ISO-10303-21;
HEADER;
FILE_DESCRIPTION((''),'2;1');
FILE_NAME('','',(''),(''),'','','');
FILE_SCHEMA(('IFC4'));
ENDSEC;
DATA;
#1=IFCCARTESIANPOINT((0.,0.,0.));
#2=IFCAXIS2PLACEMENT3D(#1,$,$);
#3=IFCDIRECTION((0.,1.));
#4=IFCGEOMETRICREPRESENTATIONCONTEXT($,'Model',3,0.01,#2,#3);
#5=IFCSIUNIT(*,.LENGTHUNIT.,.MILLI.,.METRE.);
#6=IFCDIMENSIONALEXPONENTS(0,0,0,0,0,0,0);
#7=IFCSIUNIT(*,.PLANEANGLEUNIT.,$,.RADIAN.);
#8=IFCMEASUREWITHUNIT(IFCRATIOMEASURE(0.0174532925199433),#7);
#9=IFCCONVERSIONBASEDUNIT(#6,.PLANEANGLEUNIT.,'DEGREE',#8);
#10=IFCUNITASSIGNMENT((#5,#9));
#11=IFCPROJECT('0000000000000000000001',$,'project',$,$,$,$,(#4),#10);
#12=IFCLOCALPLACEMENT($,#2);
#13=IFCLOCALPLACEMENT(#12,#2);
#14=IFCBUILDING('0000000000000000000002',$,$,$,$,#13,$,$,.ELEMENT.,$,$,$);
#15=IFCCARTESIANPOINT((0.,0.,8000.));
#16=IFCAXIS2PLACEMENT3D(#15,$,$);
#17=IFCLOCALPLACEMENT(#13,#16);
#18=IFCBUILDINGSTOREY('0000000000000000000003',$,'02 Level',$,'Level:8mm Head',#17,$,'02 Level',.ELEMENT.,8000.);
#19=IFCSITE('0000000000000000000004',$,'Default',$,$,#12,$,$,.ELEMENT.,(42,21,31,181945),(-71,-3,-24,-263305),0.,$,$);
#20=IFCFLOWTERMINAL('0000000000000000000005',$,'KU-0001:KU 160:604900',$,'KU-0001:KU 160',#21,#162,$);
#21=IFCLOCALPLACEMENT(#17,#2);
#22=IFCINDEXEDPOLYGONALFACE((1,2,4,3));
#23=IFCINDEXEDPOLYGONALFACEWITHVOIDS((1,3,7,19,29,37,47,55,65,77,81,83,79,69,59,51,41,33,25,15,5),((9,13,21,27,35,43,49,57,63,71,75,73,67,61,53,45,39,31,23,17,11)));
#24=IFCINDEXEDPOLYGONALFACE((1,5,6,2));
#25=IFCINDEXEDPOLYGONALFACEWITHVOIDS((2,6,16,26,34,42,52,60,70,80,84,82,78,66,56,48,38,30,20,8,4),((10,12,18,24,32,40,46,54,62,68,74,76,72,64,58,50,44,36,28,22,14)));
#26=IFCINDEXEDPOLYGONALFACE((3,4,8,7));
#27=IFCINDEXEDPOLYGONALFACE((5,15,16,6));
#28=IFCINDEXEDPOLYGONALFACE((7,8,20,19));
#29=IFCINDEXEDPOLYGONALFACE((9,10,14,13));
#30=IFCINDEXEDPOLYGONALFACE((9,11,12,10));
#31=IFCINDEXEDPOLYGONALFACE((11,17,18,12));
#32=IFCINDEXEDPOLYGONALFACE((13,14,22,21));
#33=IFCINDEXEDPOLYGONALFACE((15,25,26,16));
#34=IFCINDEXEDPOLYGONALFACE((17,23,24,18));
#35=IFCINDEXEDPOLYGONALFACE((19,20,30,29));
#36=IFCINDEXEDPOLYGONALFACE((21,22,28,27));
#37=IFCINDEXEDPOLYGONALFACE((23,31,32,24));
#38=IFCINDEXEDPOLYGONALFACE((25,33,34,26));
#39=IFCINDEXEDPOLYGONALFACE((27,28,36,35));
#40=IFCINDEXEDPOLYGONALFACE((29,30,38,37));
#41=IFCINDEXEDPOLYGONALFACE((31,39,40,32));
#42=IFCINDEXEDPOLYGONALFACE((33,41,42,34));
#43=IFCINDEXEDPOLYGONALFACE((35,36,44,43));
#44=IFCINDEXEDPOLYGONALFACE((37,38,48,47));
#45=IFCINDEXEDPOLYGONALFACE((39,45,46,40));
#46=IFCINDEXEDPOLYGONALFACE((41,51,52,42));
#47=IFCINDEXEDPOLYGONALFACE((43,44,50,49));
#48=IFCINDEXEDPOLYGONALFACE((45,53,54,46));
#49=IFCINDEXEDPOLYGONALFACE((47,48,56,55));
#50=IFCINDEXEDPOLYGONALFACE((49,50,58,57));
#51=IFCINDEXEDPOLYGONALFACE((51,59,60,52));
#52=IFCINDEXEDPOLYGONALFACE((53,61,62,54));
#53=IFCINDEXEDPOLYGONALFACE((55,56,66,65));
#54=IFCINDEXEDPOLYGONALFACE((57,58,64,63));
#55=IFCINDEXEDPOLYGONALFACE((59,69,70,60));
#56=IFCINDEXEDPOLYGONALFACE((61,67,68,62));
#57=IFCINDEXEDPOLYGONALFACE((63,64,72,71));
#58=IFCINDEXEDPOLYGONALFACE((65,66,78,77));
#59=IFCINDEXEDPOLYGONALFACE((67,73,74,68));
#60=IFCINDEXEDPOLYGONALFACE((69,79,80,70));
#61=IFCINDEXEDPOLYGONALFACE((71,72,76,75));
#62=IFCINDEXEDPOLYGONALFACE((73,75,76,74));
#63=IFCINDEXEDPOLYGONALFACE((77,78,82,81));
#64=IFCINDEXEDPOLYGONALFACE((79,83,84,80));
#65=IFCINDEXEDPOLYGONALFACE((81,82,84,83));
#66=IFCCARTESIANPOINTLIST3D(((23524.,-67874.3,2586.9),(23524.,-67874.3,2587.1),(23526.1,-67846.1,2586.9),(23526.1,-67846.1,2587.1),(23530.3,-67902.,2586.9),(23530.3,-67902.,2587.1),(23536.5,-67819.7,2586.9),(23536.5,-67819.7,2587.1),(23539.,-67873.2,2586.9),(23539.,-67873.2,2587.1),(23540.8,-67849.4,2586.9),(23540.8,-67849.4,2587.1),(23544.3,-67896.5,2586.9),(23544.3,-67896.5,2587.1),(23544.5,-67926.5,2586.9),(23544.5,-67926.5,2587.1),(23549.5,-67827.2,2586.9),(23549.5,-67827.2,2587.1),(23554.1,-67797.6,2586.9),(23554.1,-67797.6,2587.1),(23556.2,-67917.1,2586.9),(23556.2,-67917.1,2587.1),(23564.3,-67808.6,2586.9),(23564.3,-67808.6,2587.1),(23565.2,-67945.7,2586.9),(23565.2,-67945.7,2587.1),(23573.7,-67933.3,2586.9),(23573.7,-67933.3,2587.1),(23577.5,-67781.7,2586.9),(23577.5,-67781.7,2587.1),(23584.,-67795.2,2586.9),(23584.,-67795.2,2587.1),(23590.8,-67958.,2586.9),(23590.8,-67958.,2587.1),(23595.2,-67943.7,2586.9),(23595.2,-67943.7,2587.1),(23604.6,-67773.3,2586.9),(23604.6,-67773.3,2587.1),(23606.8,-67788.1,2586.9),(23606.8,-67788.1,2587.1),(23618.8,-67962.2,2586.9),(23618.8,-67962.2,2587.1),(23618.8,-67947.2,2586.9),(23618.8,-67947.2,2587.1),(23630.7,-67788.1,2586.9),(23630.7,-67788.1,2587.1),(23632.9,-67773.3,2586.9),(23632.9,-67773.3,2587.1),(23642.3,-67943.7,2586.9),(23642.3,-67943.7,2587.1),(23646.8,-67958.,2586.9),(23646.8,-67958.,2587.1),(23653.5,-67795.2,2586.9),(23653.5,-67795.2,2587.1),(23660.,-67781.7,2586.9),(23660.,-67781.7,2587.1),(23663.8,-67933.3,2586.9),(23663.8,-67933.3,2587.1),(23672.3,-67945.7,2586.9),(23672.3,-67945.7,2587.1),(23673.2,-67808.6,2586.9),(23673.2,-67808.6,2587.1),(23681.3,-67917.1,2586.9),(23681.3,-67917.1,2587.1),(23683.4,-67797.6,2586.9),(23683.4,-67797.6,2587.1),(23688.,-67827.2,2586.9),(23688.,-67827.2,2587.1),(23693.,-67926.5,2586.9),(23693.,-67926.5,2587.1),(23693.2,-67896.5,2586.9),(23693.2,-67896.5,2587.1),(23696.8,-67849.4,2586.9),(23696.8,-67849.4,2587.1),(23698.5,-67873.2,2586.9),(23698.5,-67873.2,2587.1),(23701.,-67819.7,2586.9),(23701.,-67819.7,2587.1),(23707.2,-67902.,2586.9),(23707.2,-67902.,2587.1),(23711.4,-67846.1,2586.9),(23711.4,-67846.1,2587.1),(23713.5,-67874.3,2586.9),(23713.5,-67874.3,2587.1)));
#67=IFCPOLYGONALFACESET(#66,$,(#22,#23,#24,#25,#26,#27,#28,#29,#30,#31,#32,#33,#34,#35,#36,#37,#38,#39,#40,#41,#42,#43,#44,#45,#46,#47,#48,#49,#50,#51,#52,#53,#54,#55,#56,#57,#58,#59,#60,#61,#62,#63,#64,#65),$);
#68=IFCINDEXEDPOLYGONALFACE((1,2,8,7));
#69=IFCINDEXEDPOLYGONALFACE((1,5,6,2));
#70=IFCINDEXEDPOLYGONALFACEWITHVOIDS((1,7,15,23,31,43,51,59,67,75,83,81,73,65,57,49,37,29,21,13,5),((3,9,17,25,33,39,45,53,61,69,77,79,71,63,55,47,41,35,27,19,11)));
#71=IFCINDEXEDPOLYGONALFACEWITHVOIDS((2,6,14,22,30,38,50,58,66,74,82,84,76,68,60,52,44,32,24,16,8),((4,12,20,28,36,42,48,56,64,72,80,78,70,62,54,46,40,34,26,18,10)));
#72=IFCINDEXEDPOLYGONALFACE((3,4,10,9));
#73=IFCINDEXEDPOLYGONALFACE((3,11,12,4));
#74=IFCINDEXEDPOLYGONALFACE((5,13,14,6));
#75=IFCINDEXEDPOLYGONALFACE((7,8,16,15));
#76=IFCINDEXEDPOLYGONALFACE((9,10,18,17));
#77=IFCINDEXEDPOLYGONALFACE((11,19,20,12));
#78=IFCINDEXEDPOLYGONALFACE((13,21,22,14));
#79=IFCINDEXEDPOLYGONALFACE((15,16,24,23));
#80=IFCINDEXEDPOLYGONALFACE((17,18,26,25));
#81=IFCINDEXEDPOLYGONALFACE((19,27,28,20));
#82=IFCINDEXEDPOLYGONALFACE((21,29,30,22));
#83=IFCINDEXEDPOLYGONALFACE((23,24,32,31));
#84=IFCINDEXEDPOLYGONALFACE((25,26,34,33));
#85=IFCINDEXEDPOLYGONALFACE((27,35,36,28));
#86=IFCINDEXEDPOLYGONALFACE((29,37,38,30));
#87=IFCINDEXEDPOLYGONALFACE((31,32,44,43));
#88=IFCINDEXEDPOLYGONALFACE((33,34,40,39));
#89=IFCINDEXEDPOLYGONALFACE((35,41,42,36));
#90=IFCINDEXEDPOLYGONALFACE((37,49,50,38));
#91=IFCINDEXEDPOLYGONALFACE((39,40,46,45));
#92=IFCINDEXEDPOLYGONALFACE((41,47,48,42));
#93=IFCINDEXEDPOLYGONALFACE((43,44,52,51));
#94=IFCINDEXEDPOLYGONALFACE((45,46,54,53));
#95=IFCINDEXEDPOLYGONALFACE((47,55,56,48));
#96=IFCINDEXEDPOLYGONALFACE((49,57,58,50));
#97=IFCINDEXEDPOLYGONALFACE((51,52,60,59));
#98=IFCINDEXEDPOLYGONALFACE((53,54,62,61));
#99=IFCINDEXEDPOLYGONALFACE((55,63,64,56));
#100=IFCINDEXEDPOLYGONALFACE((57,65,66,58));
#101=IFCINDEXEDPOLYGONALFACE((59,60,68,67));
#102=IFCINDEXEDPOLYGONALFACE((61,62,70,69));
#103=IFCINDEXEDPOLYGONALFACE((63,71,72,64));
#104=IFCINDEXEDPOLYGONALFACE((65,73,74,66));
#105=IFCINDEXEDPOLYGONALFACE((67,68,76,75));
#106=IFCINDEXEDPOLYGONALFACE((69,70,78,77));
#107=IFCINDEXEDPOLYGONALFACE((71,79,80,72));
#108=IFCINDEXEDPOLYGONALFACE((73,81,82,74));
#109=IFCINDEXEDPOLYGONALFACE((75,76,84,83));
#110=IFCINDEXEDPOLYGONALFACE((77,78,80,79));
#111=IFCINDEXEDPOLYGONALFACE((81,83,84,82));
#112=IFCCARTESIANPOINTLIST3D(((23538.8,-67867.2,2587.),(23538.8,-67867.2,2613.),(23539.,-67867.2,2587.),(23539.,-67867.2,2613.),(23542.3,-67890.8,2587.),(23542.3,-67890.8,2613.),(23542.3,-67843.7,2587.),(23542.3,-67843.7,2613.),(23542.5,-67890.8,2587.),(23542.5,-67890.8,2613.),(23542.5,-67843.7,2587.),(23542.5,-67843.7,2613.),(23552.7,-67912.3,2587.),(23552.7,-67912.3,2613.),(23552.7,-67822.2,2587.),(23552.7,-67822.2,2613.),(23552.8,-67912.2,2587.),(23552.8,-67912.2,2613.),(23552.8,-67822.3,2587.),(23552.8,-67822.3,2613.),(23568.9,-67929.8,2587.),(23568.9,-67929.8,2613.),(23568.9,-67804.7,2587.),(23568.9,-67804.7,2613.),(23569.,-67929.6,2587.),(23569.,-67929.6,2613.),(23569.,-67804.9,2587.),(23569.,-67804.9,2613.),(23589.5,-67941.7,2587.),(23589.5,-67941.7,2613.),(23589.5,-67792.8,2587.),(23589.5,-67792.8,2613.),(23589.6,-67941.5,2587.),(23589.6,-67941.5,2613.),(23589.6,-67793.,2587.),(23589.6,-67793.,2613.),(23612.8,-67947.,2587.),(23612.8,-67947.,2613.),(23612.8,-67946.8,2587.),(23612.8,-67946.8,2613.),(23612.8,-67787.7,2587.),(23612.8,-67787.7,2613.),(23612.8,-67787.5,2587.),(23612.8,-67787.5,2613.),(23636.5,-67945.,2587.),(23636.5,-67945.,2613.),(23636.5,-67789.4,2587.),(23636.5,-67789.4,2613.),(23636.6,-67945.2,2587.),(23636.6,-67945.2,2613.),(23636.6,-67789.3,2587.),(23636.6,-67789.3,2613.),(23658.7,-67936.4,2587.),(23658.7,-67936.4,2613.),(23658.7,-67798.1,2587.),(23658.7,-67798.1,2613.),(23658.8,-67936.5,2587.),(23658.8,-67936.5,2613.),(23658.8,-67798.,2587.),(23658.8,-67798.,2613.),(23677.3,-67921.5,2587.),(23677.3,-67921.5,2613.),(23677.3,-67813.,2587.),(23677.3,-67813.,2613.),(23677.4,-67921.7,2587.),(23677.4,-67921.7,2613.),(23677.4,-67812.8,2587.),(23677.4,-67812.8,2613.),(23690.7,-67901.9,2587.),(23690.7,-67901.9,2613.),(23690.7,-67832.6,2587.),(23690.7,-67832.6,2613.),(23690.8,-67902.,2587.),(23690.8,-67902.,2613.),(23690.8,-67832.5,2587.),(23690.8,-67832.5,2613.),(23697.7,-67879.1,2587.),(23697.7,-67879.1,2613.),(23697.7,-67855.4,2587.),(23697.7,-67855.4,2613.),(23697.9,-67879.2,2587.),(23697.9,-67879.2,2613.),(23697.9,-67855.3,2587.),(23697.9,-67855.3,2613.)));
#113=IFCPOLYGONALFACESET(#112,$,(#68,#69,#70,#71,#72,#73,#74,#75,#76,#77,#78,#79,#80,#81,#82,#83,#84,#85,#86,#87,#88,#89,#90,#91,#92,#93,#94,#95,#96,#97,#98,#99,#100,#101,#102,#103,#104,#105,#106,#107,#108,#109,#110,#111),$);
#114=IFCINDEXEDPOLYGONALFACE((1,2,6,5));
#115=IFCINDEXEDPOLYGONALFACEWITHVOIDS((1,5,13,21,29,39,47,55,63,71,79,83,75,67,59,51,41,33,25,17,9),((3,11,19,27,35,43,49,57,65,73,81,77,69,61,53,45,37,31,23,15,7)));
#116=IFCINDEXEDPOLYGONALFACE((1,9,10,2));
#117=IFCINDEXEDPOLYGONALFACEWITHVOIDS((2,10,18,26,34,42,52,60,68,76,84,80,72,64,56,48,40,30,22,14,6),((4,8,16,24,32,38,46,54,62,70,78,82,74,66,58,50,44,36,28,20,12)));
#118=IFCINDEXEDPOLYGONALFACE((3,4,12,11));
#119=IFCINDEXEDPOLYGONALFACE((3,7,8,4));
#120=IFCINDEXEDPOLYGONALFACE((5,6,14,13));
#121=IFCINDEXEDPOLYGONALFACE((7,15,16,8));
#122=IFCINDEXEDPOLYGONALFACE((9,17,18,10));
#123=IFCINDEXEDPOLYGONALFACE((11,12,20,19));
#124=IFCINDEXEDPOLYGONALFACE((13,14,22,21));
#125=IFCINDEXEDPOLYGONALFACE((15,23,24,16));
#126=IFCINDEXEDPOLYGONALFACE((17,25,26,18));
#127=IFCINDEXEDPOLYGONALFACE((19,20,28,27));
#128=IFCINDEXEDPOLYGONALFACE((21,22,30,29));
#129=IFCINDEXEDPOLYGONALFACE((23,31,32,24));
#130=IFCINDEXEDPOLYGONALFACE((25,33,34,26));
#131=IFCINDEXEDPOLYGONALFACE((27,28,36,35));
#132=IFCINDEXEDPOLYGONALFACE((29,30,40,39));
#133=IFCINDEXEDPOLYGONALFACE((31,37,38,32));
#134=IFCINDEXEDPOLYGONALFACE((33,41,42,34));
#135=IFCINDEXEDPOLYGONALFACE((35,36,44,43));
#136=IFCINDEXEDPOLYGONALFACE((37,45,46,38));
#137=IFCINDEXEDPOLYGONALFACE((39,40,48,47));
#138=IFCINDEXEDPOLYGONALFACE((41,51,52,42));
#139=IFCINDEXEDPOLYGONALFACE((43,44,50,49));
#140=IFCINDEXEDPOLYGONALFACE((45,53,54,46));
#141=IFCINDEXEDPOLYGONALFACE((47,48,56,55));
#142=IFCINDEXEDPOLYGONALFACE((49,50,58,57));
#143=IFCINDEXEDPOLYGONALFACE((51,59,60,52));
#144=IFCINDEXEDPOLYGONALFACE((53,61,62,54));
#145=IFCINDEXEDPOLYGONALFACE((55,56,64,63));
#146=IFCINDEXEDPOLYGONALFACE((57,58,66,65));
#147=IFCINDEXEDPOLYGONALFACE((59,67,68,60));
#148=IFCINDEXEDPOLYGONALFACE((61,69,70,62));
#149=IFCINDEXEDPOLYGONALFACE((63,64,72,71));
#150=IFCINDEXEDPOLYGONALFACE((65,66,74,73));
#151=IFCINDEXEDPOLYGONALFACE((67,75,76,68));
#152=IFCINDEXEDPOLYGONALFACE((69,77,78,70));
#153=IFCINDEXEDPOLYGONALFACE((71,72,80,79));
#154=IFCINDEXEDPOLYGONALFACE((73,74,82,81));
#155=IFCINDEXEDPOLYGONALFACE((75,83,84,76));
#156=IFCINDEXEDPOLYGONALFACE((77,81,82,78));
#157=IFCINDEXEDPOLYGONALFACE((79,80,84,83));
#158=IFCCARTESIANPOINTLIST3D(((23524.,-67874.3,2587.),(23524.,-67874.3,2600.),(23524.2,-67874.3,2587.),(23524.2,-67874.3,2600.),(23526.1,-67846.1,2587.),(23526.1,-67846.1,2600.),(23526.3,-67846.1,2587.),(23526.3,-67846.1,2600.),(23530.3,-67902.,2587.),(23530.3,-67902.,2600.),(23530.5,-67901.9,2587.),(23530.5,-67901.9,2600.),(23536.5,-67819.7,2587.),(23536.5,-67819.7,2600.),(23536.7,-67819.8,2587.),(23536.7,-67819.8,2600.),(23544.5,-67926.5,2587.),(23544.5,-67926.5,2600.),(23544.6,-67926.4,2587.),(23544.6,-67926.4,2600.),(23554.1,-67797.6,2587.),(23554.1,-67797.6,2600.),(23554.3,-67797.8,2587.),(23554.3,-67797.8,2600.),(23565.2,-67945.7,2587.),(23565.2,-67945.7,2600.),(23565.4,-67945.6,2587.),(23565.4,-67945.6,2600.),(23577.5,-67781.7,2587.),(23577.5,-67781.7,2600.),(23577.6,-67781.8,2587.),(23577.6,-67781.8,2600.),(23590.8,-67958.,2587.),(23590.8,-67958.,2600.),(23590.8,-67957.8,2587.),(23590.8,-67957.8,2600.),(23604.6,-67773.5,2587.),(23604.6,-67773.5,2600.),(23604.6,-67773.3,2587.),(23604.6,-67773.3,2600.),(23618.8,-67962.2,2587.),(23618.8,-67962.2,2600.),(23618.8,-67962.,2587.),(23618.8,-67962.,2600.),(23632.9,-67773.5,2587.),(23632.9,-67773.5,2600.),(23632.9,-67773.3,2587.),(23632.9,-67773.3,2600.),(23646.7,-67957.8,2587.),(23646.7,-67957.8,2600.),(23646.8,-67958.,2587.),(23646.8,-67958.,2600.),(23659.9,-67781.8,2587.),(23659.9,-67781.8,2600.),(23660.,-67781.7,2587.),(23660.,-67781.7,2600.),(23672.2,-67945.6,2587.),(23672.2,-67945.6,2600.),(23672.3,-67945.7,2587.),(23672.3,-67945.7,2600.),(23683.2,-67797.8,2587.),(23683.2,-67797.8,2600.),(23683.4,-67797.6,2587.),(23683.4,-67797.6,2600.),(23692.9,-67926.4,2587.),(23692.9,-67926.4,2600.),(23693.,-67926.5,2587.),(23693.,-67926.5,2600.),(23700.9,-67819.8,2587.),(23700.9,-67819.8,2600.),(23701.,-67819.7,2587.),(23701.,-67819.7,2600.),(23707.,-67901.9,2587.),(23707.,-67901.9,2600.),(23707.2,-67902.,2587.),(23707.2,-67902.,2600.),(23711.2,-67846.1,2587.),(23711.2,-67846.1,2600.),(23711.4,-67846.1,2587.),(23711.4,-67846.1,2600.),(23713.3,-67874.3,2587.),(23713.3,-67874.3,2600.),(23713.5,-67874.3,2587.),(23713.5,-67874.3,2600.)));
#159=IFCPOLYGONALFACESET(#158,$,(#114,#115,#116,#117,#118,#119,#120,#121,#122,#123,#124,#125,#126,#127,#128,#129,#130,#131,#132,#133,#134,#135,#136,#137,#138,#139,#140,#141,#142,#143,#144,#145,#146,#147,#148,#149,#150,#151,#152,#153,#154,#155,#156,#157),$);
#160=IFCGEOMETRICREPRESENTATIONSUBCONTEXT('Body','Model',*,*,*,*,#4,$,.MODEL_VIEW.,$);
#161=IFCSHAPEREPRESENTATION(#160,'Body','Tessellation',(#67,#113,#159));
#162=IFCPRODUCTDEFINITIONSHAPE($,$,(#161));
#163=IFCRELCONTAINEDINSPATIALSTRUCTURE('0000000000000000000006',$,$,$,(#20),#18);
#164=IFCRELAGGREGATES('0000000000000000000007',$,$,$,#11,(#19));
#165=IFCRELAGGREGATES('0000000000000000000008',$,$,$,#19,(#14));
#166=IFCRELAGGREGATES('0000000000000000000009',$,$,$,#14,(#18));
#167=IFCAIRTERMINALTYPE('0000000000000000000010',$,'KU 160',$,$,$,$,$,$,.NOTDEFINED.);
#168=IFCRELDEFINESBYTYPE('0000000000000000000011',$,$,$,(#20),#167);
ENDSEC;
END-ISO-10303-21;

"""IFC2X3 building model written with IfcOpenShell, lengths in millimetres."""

from ifc_helpers import new_model, entity, si_unit, converted_unit, direction, frame, frame_2d, origin, place, context, subcontext, project, spatial, hollow_circle, extrude, source, transform, mapped, type_object, type_shapes, element, save


model = new_model("IFC2X3")

# Units and contexts
model_context = context("Model", 3, precision=0.01, world=origin(), true_north=direction((0.0, 1.0)))
body_context = subcontext(model_context, "Body", "Model", "MODEL_VIEW")
ifc_project = project(units=[si_unit("LENGTHUNIT", "METRE", prefix="MILLI"), converted_unit("PLANEANGLEUNIT", "DEGREE", entity("IfcRatioMeasure", 0.0174532925199433), si_unit("PLANEANGLEUNIT", "RADIAN"), dimensions=[0, 0, 0, 0, 0, 0, 0])], contexts=[model_context])

# Site, building, storey
site_placement = place(None, origin())
site = spatial("IfcSite", under=ifc_project, at=site_placement, Name="Default", CompositionType="ELEMENT", RefLatitude=(42, 21, 31, 181945), RefLongitude=(-71, -3, -24, -263305), RefElevation=0.0)
building_placement = place(site_placement, origin())
building = spatial("IfcBuilding", under=site, at=building_placement, CompositionType="ELEMENT")
storey_placement = place(building_placement, frame((0.0, 0.0, 8000.0)))
storey = spatial("IfcBuildingStorey", under=building, at=storey_placement, Name="02 Level", ObjectType="Level:8mm Head", LongName="02 Level", CompositionType="ELEMENT", Elevation=8000.0)

# Flow terminal
air_terminal_type_1 = type_object("IfcAirTerminalType", Name="KU 160", PredefinedType="NOTDEFINED")
shared_shape_1 = source(origin(), body_context, "Body", "SweptSolid", [
    extrude(hollow_circle(Radius=95.0, WallThickness=15.0, at=frame_2d((0.0, 0.0), x_axis=(1.0, 0.0))), frame((12.9, 0.0, 0.0), z_axis=(1.0, 0.0, 0.0), x_axis=(0.0, -1.0, 0.0)), (0.0, 0.0, 1.0), 0.2),
    extrude(hollow_circle(Radius=80.0, WallThickness=0.2, at=frame_2d((0.0, 0.0), x_axis=(1.0, 0.0))), frame((-13.0, 0.0, 0.0), z_axis=(1.0, 0.0, 0.0), x_axis=(0.0, 0.0, -1.0)), (0.0, 0.0, 1.0), 26.0),
    extrude(hollow_circle(Radius=95.0, WallThickness=0.2, at=frame_2d((0.0, 0.0), x_axis=(1.0, 0.0))), frame((0.0, 0.0, 0.0), z_axis=(1.0, 0.0, 0.0), x_axis=(0.0, -1.0, 0.0)), (0.0, 0.0, 1.0), 13.0),
])
type_shapes(air_terminal_type_1, [shared_shape_1])
for number, where, z_axis, x_axis, name in (
    (1, (23618.8, -67867.2, 2600.0), (1.0, 0.0, 0.0), (0.0, 0.0, -1.0), "KU-0001:KU 160:604900"),
):
    element("IfcFlowTerminal", number, at=place(storey_placement, frame(where, z_axis=z_axis, x_axis=x_axis)), inside=storey, type_object=air_terminal_type_1, Name=name, ObjectType="KU-0001:KU 160", context=body_context, shape_type="MappedRepresentation", body=[
        mapped(shared_shape_1, transform((0.0, 0.0, 0.0), scale=1.0)),
    ])

save(model, "model.ifc")
